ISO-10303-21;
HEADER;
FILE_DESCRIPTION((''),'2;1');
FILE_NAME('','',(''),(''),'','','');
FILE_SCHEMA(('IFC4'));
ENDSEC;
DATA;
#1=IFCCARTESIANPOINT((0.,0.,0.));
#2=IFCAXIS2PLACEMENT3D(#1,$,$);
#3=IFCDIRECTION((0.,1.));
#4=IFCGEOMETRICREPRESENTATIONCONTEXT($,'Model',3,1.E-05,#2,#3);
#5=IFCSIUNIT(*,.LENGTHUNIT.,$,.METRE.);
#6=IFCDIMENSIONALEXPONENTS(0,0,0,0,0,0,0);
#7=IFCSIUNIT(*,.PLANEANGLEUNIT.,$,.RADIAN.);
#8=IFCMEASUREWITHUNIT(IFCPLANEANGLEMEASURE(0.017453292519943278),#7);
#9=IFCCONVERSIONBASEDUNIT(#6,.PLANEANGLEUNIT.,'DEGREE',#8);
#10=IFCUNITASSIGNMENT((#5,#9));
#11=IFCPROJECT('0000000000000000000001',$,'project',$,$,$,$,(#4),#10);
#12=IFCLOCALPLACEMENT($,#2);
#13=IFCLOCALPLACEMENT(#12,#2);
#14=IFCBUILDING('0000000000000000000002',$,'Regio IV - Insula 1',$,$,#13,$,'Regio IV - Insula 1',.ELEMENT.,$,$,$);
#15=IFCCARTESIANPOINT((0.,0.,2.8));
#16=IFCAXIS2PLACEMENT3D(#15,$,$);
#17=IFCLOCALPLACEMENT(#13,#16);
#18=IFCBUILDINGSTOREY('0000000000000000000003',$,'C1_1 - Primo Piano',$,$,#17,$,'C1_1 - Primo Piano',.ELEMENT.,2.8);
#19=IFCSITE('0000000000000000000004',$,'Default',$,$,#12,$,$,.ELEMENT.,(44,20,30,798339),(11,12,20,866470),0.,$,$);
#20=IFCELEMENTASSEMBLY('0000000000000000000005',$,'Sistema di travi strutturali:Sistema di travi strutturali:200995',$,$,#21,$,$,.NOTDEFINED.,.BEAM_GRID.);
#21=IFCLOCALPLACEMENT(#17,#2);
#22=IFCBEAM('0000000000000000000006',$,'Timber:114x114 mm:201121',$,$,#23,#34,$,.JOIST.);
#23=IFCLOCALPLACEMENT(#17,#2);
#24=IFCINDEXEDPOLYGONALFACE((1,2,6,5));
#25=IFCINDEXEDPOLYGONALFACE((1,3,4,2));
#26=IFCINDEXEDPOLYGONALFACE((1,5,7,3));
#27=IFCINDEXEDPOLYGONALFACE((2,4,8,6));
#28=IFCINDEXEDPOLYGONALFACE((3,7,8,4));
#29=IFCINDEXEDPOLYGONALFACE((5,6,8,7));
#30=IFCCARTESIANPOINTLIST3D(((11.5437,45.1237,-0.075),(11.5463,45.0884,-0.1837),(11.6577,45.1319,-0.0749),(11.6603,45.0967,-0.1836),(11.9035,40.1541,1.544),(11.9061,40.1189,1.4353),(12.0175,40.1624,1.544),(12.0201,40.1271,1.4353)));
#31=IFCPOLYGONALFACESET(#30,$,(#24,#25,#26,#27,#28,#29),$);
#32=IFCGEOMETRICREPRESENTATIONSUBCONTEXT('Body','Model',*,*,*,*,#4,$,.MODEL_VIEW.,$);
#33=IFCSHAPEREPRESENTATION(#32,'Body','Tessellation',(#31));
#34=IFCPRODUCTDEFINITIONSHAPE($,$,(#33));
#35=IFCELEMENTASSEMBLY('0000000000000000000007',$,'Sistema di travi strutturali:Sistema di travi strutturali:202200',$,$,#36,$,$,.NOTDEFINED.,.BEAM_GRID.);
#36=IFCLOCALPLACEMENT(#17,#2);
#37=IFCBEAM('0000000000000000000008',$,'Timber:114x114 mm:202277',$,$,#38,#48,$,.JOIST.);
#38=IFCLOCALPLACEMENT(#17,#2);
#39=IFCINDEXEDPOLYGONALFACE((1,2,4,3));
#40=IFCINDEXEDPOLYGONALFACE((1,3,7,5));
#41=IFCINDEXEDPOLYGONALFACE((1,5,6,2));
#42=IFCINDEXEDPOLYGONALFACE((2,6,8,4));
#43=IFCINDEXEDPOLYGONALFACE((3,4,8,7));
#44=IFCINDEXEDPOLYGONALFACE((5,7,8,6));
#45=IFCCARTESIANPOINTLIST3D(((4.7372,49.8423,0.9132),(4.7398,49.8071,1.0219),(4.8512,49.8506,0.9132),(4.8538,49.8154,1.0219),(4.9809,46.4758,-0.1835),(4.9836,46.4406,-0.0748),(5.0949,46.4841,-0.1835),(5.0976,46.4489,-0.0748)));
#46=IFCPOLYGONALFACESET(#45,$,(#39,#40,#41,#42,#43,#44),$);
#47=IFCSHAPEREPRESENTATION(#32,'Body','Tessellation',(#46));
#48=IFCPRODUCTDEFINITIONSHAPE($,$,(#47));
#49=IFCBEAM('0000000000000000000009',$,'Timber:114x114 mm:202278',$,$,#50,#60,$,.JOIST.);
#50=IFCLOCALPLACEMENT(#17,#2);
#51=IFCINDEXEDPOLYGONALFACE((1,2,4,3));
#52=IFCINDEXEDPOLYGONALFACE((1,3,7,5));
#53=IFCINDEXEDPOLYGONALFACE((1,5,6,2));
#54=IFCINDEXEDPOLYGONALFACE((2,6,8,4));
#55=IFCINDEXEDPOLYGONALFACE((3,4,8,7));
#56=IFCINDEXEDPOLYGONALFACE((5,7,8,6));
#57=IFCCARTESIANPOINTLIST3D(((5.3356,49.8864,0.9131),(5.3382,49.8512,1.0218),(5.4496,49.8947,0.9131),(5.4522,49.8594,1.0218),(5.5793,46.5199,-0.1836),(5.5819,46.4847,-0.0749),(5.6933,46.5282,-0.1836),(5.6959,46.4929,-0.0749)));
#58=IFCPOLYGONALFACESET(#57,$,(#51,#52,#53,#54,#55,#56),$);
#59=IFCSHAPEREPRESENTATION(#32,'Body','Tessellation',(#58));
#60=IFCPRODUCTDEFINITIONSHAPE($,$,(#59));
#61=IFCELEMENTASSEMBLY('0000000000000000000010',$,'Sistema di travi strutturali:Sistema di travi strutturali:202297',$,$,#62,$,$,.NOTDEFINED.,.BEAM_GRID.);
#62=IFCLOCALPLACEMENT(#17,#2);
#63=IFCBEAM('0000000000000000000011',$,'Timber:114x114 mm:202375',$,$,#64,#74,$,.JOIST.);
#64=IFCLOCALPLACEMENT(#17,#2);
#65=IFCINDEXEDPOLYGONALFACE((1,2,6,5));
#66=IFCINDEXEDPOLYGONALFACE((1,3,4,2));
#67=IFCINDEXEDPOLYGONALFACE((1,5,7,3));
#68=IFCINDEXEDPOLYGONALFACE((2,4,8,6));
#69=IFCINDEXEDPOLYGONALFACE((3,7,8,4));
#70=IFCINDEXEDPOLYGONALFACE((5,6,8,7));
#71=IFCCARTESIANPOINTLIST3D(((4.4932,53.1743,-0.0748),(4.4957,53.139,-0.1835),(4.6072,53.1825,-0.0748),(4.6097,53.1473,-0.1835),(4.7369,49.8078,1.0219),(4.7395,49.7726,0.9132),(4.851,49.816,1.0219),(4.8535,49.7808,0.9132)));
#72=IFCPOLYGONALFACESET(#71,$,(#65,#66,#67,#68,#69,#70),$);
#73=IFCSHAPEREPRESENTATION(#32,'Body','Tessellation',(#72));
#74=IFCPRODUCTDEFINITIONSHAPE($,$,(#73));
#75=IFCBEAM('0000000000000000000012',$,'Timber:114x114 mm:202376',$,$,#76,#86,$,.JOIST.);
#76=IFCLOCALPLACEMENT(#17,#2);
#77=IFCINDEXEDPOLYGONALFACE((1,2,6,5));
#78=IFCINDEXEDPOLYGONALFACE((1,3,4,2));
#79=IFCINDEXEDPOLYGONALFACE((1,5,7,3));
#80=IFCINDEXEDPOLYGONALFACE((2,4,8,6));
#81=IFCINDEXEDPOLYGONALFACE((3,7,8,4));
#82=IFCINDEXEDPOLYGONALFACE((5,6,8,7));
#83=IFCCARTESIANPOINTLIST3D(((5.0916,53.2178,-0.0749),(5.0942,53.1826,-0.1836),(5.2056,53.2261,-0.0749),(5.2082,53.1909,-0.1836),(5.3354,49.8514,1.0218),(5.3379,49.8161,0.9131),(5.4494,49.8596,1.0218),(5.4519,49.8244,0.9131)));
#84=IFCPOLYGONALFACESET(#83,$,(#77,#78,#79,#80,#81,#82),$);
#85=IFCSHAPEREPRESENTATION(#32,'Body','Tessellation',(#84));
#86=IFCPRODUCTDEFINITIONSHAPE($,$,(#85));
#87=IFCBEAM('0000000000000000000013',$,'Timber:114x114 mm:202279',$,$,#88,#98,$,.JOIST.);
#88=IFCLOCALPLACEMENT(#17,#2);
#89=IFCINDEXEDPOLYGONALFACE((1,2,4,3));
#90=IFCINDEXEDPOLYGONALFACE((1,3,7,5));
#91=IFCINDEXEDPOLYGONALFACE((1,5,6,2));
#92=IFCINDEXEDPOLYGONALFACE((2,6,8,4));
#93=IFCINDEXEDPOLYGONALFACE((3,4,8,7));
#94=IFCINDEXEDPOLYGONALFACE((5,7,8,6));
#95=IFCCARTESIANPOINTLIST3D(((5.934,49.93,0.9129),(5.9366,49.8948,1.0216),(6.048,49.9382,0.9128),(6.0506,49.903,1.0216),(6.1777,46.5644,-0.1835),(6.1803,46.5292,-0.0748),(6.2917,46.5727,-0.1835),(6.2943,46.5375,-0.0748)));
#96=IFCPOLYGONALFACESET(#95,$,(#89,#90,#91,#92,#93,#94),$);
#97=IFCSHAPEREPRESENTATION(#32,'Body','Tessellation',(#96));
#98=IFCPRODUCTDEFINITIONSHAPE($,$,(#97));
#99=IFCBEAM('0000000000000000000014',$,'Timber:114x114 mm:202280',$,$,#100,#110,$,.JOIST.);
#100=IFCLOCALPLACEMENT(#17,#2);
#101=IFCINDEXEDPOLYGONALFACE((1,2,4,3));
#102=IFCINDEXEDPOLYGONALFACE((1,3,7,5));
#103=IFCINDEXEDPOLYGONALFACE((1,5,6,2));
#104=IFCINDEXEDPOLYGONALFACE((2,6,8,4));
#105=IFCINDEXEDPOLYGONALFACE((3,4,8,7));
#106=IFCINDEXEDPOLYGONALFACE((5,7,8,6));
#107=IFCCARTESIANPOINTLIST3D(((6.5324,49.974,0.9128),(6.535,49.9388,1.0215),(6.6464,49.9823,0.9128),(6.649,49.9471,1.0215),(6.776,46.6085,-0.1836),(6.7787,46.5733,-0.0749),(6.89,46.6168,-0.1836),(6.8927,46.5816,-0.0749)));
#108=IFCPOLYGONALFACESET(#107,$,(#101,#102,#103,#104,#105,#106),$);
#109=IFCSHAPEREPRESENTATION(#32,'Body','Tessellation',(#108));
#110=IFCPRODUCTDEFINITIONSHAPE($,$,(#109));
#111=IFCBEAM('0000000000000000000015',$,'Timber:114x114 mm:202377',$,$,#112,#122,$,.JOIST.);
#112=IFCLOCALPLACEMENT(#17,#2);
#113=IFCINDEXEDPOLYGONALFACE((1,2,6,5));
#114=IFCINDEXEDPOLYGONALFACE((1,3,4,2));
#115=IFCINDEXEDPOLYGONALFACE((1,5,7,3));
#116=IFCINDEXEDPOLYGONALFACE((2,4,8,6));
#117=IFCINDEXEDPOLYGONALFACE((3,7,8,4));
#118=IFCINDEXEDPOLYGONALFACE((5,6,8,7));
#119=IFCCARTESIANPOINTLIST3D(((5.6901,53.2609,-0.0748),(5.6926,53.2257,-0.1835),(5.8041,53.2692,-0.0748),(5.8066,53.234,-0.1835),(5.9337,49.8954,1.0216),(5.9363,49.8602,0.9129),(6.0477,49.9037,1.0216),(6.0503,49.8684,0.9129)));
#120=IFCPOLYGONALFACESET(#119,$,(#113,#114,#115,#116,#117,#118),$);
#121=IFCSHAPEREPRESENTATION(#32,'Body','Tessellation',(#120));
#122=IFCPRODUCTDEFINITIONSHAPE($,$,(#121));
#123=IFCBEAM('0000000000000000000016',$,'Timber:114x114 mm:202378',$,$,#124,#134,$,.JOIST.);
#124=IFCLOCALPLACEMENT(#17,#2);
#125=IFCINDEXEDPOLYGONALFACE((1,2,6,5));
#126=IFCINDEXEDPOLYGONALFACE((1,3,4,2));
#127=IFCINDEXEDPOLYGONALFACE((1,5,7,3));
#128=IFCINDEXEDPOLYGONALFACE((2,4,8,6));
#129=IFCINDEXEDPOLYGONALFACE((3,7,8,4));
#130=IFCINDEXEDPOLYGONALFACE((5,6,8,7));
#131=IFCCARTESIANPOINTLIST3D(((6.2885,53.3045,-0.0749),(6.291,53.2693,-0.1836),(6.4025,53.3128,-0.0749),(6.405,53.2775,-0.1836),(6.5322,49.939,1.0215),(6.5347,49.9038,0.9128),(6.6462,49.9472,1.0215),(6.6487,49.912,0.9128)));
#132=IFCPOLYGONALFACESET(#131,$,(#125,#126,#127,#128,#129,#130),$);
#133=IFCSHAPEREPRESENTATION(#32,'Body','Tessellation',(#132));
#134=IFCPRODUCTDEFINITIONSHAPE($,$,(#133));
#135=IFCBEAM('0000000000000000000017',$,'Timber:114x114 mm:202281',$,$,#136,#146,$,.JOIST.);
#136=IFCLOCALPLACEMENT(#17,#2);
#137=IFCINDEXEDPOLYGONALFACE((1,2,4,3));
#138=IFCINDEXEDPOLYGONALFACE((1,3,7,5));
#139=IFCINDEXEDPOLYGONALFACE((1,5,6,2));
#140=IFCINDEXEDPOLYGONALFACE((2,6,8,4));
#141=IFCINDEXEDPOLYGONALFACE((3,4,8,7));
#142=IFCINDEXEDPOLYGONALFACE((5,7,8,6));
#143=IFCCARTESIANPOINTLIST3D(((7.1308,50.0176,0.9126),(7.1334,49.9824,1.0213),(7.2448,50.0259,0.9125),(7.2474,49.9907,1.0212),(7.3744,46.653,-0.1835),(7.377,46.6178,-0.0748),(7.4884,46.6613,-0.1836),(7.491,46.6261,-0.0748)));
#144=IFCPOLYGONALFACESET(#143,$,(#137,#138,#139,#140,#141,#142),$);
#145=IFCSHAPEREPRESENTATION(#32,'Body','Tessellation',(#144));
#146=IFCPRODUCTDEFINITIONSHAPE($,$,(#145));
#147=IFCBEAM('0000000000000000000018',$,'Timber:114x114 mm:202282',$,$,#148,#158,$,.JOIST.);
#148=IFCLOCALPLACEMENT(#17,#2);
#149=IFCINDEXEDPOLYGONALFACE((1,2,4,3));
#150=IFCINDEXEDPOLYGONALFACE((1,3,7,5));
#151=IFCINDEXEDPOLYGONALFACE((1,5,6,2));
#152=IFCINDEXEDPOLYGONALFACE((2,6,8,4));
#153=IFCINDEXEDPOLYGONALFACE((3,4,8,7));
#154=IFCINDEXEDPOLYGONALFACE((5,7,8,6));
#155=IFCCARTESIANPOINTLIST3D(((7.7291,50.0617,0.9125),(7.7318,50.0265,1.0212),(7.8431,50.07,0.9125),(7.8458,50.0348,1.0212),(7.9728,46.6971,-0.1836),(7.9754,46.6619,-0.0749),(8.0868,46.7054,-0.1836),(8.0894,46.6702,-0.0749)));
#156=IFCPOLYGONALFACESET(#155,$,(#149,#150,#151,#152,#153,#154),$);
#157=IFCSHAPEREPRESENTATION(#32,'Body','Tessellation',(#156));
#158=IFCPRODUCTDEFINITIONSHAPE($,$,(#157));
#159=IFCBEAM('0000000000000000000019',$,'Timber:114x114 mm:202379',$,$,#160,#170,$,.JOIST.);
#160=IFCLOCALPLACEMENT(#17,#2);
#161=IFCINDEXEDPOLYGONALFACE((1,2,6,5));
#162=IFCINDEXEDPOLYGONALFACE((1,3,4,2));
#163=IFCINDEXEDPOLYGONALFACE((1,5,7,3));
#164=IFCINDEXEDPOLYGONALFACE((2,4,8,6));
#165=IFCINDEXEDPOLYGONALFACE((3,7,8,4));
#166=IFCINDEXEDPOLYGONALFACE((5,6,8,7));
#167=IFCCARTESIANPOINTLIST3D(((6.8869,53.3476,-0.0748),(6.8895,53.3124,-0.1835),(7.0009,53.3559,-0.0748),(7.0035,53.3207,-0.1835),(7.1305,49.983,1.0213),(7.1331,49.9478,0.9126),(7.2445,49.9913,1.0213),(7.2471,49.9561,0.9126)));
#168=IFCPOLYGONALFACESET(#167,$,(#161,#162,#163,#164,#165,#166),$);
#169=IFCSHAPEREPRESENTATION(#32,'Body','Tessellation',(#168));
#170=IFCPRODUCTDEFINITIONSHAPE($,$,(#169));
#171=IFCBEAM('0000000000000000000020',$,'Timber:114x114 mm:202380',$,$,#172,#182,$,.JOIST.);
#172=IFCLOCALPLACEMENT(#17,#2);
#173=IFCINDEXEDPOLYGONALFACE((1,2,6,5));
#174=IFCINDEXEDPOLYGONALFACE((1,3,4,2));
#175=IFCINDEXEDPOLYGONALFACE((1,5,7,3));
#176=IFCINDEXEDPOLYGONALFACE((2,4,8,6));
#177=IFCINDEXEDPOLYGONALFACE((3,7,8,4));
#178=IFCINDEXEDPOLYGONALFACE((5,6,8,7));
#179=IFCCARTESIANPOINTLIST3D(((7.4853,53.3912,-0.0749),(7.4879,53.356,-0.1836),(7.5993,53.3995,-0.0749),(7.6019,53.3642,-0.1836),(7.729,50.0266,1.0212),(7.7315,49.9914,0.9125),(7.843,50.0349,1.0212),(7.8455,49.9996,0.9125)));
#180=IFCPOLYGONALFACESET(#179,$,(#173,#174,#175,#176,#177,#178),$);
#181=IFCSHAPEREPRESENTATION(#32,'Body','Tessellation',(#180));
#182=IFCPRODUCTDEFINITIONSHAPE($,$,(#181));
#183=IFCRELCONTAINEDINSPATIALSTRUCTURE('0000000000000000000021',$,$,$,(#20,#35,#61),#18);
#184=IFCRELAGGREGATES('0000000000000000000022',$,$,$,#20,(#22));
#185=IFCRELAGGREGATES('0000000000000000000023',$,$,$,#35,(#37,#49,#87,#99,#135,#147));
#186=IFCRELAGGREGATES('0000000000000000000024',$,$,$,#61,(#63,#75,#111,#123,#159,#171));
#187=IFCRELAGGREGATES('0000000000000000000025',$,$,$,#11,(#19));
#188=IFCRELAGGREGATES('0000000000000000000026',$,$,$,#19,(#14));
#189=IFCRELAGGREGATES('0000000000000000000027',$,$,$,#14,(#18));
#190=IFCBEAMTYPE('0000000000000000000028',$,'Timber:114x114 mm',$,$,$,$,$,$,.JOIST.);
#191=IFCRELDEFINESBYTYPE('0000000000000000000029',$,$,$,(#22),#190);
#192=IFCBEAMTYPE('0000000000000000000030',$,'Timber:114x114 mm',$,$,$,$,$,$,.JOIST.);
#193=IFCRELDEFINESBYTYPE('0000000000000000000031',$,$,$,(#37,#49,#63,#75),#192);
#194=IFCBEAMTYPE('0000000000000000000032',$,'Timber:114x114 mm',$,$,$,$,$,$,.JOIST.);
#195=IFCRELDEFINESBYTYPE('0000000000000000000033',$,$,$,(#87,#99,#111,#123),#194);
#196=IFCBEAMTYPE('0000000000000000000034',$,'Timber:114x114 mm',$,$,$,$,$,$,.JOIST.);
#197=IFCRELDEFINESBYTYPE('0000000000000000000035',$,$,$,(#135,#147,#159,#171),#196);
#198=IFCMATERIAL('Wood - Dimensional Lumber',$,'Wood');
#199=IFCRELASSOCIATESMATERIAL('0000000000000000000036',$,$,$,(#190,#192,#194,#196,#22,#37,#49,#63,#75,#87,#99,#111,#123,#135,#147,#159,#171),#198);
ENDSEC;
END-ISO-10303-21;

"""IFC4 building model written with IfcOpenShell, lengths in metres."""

from ifc_helpers import new_model, entity, si_unit, converted_unit, direction, frame, origin, origin_2d_with_axis, place, context, subcontext, project, spatial, rectangle, extrude, source, transform, mapped, material, material_profile, profile_set, profile_usage, type_object, type_shapes, element, aggregate, save


model = new_model("IFC4")

# Units and contexts
model_context = context("Model", 3, precision=1e-05, world=origin(), true_north=direction((0.0, 1.0)))
body_context = subcontext(model_context, "Body", "Model", "MODEL_VIEW")
ifc_project = project(units=[si_unit("LENGTHUNIT", "METRE"), converted_unit("PLANEANGLEUNIT", "DEGREE", entity("IfcPlaneAngleMeasure", 0.017453292519943278), si_unit("PLANEANGLEUNIT", "RADIAN"), dimensions=[0, 0, 0, 0, 0, 0, 0])], contexts=[model_context])

# Site, building, storey
site_placement = place(None, origin())
site = spatial("IfcSite", under=ifc_project, at=site_placement, Name="Default", CompositionType="ELEMENT", RefLatitude=(44, 20, 30, 798339), RefLongitude=(11, 12, 20, 866470), RefElevation=0.0)
building_placement = place(site_placement, origin())
building = spatial("IfcBuilding", under=site, at=building_placement, Name="Regio IV - Insula 1", LongName="Regio IV - Insula 1", CompositionType="ELEMENT")
storey_placement = place(building_placement, frame((0.0, 0.0, 2.8)))
storey = spatial("IfcBuildingStorey", under=building, at=storey_placement, Name="C1_1 - Primo Piano", LongName="C1_1 - Primo Piano", CompositionType="ELEMENT", Elevation=2.8)

# Element assembly, beam
assembly_1_placement = place(storey_placement, origin())
assembly_1 = element("IfcElementAssembly", 1, at=assembly_1_placement, inside=storey, Name="Sistema di travi strutturali:Sistema di travi strutturali:200995", AssemblyPlace="NOTDEFINED", PredefinedType="BEAM_GRID")
ifc_material = material(Name="Wood - Dimensional Lumber", Category="Wood")
ifc_material_profile = material_profile(ifc_material, rectangle(XDim=5.294, YDim=0.1143, at=origin_2d_with_axis()), Name="114x114 mm")
ifc_profile_set = profile_set([ifc_material_profile], Name="114x114 mm")
ifc_profile_usage = profile_usage(ifc_profile_set, cardinal=8)
beam_type_1 = type_object("IfcBeamType", Name="Timber:114x114 mm", PredefinedType="JOIST", material=ifc_profile_set)
shared_shape_1 = source(origin(), body_context, "Body", "SweptSolid", [
    extrude(rectangle(XDim=5.239, YDim=0.1143, at=origin_2d_with_axis()), frame((0.0, 0.0, -0.0572), z_axis=(0.0, 0.0, 1.0), x_axis=(-1.0, 0.0, 0.0)), (0.0, 0.0, 1.0), 0.1143),
])
type_shapes(beam_type_1, [shared_shape_1])
beam_1_placement = place(assembly_1_placement, frame((11.7819, 42.6254, 0.6802), z_axis=(-0.022823, 0.308173, 0.951057), x_axis=(0.068685, -0.948573, 0.309017)))
beam_1 = element("IfcBeam", 2, at=beam_1_placement, type_object=beam_type_1, material=ifc_profile_usage, Name="Timber:114x114 mm:201121", PredefinedType="JOIST", context=body_context, shape_type="MappedRepresentation", body=[
    mapped(shared_shape_1, transform((0.0, 0.0, 0.0), scale=1.0)),
])
aggregate(assembly_1, [beam_1])

# Element assemblies, beams
assembly_2_placement = place(storey_placement, origin())
assembly_2 = element("IfcElementAssembly", 3, at=assembly_2_placement, inside=storey, Name="Sistema di travi strutturali:Sistema di travi strutturali:202200", AssemblyPlace="NOTDEFINED", PredefinedType="BEAM_GRID")
beam_type_2 = type_object("IfcBeamType", Name="Timber:114x114 mm", PredefinedType="JOIST", material=ifc_profile_set)
shared_shape_2 = source(origin(), body_context, "Body", "SweptSolid", [
    extrude(rectangle(XDim=3.549, YDim=0.1143, at=origin_2d_with_axis()), frame((0.0, 0.0, -0.0572), z_axis=(0.0, 0.0, 1.0), x_axis=(-1.0, 0.0, 0.0)), (0.0, 0.0, 1.0), 0.1143),
])
type_shapes(beam_type_2, [shared_shape_2])
beam_2_placement = place(assembly_2_placement, frame((4.9174, 48.1456, 0.4192), z_axis=(0.022823, -0.308173, 0.951057), x_axis=(0.068685, -0.948573, -0.309017)))
beam_2 = element("IfcBeam", 4, at=beam_2_placement, type_object=beam_type_2, material=ifc_profile_usage, Name="Timber:114x114 mm:202277", PredefinedType="JOIST", context=body_context, shape_type="MappedRepresentation", body=[
    mapped(shared_shape_2, transform((0.0, 0.0, 0.0), scale=1.0)),
])
beam_3_placement = place(assembly_2_placement, frame((5.5157, 48.1897, 0.4191), z_axis=(0.022823, -0.308173, 0.951057), x_axis=(0.068685, -0.948573, -0.309017)))
beam_3 = element("IfcBeam", 5, at=beam_3_placement, type_object=beam_type_2, material=ifc_profile_usage, Name="Timber:114x114 mm:202278", PredefinedType="JOIST", context=body_context, shape_type="MappedRepresentation", body=[
    mapped(shared_shape_2, transform((0.0, 0.0, 0.0), scale=1.0)),
])
assembly_3_placement = place(storey_placement, origin())
assembly_3 = element("IfcElementAssembly", 6, at=assembly_3_placement, inside=storey, Name="Sistema di travi strutturali:Sistema di travi strutturali:202297", AssemblyPlace="NOTDEFINED", PredefinedType="BEAM_GRID")
beam_4_placement = place(assembly_3_placement, frame((4.6733, 51.4775, 0.4192), z_axis=(-0.022317, 0.30821, 0.951057), x_axis=(0.068685, -0.948573, 0.309017)))
beam_4 = element("IfcBeam", 7, at=beam_4_placement, type_object=beam_type_2, material=ifc_profile_usage, Name="Timber:114x114 mm:202375", PredefinedType="JOIST", context=body_context, shape_type="MappedRepresentation", body=[
    mapped(shared_shape_2, transform((0.0, 0.0, 0.0), scale=1.0)),
])
beam_5_placement = place(assembly_3_placement, frame((5.2718, 51.5211, 0.4191), z_axis=(-0.022317, 0.30821, 0.951057), x_axis=(0.068685, -0.948573, 0.309017)))
beam_5 = element("IfcBeam", 8, at=beam_5_placement, type_object=beam_type_2, material=ifc_profile_usage, Name="Timber:114x114 mm:202376", PredefinedType="JOIST", context=body_context, shape_type="MappedRepresentation", body=[
    mapped(shared_shape_2, transform((0.0, 0.0, 0.0), scale=1.0)),
])

# Beams
beam_type_3 = type_object("IfcBeamType", Name="Timber:114x114 mm", PredefinedType="JOIST", material=ifc_profile_set)
shared_shape_3 = source(origin(), body_context, "Body", "SweptSolid", [
    extrude(rectangle(XDim=3.548, YDim=0.1143, at=origin_2d_with_axis()), frame((0.0, 0.0, -0.0572), z_axis=(0.0, 0.0, 1.0), x_axis=(-1.0, 0.0, 0.0)), (0.0, 0.0, 1.0), 0.1143),
])
type_shapes(beam_type_3, [shared_shape_3])
beam_6_placement = place(assembly_2_placement, frame((6.1141, 48.2337, 0.419), z_axis=(0.022823, -0.308173, 0.951057), x_axis=(0.068685, -0.948573, -0.309017)))
beam_6 = element("IfcBeam", 9, at=beam_6_placement, type_object=beam_type_3, material=ifc_profile_usage, Name="Timber:114x114 mm:202279", PredefinedType="JOIST", context=body_context, shape_type="MappedRepresentation", body=[
    mapped(shared_shape_3, transform((0.0, 0.0, 0.0), scale=1.0)),
])
beam_7_placement = place(assembly_2_placement, frame((6.7125, 48.2778, 0.4189), z_axis=(0.022823, -0.308173, 0.951057), x_axis=(0.068685, -0.948573, -0.309017)))
beam_7 = element("IfcBeam", 10, at=beam_7_placement, type_object=beam_type_3, material=ifc_profile_usage, Name="Timber:114x114 mm:202280", PredefinedType="JOIST", context=body_context, shape_type="MappedRepresentation", body=[
    mapped(shared_shape_3, transform((0.0, 0.0, 0.0), scale=1.0)),
])
beam_8_placement = place(assembly_3_placement, frame((5.8702, 51.5647, 0.419), z_axis=(-0.022317, 0.30821, 0.951057), x_axis=(0.068685, -0.948573, 0.309017)))
beam_8 = element("IfcBeam", 11, at=beam_8_placement, type_object=beam_type_3, material=ifc_profile_usage, Name="Timber:114x114 mm:202377", PredefinedType="JOIST", context=body_context, shape_type="MappedRepresentation", body=[
    mapped(shared_shape_3, transform((0.0, 0.0, 0.0), scale=1.0)),
])
beam_9_placement = place(assembly_3_placement, frame((6.4686, 51.6083, 0.419), z_axis=(-0.022317, 0.30821, 0.951057), x_axis=(0.068685, -0.948573, 0.309017)))
beam_9 = element("IfcBeam", 12, at=beam_9_placement, type_object=beam_type_3, material=ifc_profile_usage, Name="Timber:114x114 mm:202378", PredefinedType="JOIST", context=body_context, shape_type="MappedRepresentation", body=[
    mapped(shared_shape_3, transform((0.0, 0.0, 0.0), scale=1.0)),
])
beam_type_4 = type_object("IfcBeamType", Name="Timber:114x114 mm", PredefinedType="JOIST", material=ifc_profile_set)
shared_shape_4 = source(origin(), body_context, "Body", "SweptSolid", [
    extrude(rectangle(XDim=3.547, YDim=0.1143, at=origin_2d_with_axis()), frame((0.0, 0.0, -0.0572), z_axis=(0.0, 0.0, 1.0), x_axis=(-1.0, 0.0, 0.0)), (0.0, 0.0, 1.0), 0.1143),
])
type_shapes(beam_type_4, [shared_shape_4])
beam_10_placement = place(assembly_2_placement, frame((7.3109, 48.3219, 0.4189), z_axis=(0.022823, -0.308173, 0.951057), x_axis=(0.068685, -0.948573, -0.309017)))
beam_10 = element("IfcBeam", 13, at=beam_10_placement, type_object=beam_type_4, material=ifc_profile_usage, Name="Timber:114x114 mm:202281", PredefinedType="JOIST", context=body_context, shape_type="MappedRepresentation", body=[
    mapped(shared_shape_4, transform((0.0, 0.0, 0.0), scale=1.0)),
])
beam_11_placement = place(assembly_2_placement, frame((7.9093, 48.3659, 0.4188), z_axis=(0.022823, -0.308173, 0.951057), x_axis=(0.068685, -0.948573, -0.309017)))
beam_11 = element("IfcBeam", 14, at=beam_11_placement, type_object=beam_type_4, material=ifc_profile_usage, Name="Timber:114x114 mm:202282", PredefinedType="JOIST", context=body_context, shape_type="MappedRepresentation", body=[
    mapped(shared_shape_4, transform((0.0, 0.0, 0.0), scale=1.0)),
])
beam_12_placement = place(assembly_3_placement, frame((7.067, 51.6518, 0.4189), z_axis=(-0.022317, 0.30821, 0.951057), x_axis=(0.068685, -0.948573, 0.309017)))
beam_12 = element("IfcBeam", 15, at=beam_12_placement, type_object=beam_type_4, material=ifc_profile_usage, Name="Timber:114x114 mm:202379", PredefinedType="JOIST", context=body_context, shape_type="MappedRepresentation", body=[
    mapped(shared_shape_4, transform((0.0, 0.0, 0.0), scale=1.0)),
])
beam_13_placement = place(assembly_3_placement, frame((7.6654, 51.6954, 0.4188), z_axis=(-0.022317, 0.30821, 0.951057), x_axis=(0.068685, -0.948573, 0.309017)))
beam_13 = element("IfcBeam", 16, at=beam_13_placement, type_object=beam_type_4, material=ifc_profile_usage, Name="Timber:114x114 mm:202380", PredefinedType="JOIST", context=body_context, shape_type="MappedRepresentation", body=[
    mapped(shared_shape_4, transform((0.0, 0.0, 0.0), scale=1.0)),
])
aggregate(assembly_2, [beam_2, beam_3, beam_6, beam_7, beam_10, beam_11])
aggregate(assembly_3, [beam_4, beam_5, beam_8, beam_9, beam_12, beam_13])

save(model, "model.ifc")
